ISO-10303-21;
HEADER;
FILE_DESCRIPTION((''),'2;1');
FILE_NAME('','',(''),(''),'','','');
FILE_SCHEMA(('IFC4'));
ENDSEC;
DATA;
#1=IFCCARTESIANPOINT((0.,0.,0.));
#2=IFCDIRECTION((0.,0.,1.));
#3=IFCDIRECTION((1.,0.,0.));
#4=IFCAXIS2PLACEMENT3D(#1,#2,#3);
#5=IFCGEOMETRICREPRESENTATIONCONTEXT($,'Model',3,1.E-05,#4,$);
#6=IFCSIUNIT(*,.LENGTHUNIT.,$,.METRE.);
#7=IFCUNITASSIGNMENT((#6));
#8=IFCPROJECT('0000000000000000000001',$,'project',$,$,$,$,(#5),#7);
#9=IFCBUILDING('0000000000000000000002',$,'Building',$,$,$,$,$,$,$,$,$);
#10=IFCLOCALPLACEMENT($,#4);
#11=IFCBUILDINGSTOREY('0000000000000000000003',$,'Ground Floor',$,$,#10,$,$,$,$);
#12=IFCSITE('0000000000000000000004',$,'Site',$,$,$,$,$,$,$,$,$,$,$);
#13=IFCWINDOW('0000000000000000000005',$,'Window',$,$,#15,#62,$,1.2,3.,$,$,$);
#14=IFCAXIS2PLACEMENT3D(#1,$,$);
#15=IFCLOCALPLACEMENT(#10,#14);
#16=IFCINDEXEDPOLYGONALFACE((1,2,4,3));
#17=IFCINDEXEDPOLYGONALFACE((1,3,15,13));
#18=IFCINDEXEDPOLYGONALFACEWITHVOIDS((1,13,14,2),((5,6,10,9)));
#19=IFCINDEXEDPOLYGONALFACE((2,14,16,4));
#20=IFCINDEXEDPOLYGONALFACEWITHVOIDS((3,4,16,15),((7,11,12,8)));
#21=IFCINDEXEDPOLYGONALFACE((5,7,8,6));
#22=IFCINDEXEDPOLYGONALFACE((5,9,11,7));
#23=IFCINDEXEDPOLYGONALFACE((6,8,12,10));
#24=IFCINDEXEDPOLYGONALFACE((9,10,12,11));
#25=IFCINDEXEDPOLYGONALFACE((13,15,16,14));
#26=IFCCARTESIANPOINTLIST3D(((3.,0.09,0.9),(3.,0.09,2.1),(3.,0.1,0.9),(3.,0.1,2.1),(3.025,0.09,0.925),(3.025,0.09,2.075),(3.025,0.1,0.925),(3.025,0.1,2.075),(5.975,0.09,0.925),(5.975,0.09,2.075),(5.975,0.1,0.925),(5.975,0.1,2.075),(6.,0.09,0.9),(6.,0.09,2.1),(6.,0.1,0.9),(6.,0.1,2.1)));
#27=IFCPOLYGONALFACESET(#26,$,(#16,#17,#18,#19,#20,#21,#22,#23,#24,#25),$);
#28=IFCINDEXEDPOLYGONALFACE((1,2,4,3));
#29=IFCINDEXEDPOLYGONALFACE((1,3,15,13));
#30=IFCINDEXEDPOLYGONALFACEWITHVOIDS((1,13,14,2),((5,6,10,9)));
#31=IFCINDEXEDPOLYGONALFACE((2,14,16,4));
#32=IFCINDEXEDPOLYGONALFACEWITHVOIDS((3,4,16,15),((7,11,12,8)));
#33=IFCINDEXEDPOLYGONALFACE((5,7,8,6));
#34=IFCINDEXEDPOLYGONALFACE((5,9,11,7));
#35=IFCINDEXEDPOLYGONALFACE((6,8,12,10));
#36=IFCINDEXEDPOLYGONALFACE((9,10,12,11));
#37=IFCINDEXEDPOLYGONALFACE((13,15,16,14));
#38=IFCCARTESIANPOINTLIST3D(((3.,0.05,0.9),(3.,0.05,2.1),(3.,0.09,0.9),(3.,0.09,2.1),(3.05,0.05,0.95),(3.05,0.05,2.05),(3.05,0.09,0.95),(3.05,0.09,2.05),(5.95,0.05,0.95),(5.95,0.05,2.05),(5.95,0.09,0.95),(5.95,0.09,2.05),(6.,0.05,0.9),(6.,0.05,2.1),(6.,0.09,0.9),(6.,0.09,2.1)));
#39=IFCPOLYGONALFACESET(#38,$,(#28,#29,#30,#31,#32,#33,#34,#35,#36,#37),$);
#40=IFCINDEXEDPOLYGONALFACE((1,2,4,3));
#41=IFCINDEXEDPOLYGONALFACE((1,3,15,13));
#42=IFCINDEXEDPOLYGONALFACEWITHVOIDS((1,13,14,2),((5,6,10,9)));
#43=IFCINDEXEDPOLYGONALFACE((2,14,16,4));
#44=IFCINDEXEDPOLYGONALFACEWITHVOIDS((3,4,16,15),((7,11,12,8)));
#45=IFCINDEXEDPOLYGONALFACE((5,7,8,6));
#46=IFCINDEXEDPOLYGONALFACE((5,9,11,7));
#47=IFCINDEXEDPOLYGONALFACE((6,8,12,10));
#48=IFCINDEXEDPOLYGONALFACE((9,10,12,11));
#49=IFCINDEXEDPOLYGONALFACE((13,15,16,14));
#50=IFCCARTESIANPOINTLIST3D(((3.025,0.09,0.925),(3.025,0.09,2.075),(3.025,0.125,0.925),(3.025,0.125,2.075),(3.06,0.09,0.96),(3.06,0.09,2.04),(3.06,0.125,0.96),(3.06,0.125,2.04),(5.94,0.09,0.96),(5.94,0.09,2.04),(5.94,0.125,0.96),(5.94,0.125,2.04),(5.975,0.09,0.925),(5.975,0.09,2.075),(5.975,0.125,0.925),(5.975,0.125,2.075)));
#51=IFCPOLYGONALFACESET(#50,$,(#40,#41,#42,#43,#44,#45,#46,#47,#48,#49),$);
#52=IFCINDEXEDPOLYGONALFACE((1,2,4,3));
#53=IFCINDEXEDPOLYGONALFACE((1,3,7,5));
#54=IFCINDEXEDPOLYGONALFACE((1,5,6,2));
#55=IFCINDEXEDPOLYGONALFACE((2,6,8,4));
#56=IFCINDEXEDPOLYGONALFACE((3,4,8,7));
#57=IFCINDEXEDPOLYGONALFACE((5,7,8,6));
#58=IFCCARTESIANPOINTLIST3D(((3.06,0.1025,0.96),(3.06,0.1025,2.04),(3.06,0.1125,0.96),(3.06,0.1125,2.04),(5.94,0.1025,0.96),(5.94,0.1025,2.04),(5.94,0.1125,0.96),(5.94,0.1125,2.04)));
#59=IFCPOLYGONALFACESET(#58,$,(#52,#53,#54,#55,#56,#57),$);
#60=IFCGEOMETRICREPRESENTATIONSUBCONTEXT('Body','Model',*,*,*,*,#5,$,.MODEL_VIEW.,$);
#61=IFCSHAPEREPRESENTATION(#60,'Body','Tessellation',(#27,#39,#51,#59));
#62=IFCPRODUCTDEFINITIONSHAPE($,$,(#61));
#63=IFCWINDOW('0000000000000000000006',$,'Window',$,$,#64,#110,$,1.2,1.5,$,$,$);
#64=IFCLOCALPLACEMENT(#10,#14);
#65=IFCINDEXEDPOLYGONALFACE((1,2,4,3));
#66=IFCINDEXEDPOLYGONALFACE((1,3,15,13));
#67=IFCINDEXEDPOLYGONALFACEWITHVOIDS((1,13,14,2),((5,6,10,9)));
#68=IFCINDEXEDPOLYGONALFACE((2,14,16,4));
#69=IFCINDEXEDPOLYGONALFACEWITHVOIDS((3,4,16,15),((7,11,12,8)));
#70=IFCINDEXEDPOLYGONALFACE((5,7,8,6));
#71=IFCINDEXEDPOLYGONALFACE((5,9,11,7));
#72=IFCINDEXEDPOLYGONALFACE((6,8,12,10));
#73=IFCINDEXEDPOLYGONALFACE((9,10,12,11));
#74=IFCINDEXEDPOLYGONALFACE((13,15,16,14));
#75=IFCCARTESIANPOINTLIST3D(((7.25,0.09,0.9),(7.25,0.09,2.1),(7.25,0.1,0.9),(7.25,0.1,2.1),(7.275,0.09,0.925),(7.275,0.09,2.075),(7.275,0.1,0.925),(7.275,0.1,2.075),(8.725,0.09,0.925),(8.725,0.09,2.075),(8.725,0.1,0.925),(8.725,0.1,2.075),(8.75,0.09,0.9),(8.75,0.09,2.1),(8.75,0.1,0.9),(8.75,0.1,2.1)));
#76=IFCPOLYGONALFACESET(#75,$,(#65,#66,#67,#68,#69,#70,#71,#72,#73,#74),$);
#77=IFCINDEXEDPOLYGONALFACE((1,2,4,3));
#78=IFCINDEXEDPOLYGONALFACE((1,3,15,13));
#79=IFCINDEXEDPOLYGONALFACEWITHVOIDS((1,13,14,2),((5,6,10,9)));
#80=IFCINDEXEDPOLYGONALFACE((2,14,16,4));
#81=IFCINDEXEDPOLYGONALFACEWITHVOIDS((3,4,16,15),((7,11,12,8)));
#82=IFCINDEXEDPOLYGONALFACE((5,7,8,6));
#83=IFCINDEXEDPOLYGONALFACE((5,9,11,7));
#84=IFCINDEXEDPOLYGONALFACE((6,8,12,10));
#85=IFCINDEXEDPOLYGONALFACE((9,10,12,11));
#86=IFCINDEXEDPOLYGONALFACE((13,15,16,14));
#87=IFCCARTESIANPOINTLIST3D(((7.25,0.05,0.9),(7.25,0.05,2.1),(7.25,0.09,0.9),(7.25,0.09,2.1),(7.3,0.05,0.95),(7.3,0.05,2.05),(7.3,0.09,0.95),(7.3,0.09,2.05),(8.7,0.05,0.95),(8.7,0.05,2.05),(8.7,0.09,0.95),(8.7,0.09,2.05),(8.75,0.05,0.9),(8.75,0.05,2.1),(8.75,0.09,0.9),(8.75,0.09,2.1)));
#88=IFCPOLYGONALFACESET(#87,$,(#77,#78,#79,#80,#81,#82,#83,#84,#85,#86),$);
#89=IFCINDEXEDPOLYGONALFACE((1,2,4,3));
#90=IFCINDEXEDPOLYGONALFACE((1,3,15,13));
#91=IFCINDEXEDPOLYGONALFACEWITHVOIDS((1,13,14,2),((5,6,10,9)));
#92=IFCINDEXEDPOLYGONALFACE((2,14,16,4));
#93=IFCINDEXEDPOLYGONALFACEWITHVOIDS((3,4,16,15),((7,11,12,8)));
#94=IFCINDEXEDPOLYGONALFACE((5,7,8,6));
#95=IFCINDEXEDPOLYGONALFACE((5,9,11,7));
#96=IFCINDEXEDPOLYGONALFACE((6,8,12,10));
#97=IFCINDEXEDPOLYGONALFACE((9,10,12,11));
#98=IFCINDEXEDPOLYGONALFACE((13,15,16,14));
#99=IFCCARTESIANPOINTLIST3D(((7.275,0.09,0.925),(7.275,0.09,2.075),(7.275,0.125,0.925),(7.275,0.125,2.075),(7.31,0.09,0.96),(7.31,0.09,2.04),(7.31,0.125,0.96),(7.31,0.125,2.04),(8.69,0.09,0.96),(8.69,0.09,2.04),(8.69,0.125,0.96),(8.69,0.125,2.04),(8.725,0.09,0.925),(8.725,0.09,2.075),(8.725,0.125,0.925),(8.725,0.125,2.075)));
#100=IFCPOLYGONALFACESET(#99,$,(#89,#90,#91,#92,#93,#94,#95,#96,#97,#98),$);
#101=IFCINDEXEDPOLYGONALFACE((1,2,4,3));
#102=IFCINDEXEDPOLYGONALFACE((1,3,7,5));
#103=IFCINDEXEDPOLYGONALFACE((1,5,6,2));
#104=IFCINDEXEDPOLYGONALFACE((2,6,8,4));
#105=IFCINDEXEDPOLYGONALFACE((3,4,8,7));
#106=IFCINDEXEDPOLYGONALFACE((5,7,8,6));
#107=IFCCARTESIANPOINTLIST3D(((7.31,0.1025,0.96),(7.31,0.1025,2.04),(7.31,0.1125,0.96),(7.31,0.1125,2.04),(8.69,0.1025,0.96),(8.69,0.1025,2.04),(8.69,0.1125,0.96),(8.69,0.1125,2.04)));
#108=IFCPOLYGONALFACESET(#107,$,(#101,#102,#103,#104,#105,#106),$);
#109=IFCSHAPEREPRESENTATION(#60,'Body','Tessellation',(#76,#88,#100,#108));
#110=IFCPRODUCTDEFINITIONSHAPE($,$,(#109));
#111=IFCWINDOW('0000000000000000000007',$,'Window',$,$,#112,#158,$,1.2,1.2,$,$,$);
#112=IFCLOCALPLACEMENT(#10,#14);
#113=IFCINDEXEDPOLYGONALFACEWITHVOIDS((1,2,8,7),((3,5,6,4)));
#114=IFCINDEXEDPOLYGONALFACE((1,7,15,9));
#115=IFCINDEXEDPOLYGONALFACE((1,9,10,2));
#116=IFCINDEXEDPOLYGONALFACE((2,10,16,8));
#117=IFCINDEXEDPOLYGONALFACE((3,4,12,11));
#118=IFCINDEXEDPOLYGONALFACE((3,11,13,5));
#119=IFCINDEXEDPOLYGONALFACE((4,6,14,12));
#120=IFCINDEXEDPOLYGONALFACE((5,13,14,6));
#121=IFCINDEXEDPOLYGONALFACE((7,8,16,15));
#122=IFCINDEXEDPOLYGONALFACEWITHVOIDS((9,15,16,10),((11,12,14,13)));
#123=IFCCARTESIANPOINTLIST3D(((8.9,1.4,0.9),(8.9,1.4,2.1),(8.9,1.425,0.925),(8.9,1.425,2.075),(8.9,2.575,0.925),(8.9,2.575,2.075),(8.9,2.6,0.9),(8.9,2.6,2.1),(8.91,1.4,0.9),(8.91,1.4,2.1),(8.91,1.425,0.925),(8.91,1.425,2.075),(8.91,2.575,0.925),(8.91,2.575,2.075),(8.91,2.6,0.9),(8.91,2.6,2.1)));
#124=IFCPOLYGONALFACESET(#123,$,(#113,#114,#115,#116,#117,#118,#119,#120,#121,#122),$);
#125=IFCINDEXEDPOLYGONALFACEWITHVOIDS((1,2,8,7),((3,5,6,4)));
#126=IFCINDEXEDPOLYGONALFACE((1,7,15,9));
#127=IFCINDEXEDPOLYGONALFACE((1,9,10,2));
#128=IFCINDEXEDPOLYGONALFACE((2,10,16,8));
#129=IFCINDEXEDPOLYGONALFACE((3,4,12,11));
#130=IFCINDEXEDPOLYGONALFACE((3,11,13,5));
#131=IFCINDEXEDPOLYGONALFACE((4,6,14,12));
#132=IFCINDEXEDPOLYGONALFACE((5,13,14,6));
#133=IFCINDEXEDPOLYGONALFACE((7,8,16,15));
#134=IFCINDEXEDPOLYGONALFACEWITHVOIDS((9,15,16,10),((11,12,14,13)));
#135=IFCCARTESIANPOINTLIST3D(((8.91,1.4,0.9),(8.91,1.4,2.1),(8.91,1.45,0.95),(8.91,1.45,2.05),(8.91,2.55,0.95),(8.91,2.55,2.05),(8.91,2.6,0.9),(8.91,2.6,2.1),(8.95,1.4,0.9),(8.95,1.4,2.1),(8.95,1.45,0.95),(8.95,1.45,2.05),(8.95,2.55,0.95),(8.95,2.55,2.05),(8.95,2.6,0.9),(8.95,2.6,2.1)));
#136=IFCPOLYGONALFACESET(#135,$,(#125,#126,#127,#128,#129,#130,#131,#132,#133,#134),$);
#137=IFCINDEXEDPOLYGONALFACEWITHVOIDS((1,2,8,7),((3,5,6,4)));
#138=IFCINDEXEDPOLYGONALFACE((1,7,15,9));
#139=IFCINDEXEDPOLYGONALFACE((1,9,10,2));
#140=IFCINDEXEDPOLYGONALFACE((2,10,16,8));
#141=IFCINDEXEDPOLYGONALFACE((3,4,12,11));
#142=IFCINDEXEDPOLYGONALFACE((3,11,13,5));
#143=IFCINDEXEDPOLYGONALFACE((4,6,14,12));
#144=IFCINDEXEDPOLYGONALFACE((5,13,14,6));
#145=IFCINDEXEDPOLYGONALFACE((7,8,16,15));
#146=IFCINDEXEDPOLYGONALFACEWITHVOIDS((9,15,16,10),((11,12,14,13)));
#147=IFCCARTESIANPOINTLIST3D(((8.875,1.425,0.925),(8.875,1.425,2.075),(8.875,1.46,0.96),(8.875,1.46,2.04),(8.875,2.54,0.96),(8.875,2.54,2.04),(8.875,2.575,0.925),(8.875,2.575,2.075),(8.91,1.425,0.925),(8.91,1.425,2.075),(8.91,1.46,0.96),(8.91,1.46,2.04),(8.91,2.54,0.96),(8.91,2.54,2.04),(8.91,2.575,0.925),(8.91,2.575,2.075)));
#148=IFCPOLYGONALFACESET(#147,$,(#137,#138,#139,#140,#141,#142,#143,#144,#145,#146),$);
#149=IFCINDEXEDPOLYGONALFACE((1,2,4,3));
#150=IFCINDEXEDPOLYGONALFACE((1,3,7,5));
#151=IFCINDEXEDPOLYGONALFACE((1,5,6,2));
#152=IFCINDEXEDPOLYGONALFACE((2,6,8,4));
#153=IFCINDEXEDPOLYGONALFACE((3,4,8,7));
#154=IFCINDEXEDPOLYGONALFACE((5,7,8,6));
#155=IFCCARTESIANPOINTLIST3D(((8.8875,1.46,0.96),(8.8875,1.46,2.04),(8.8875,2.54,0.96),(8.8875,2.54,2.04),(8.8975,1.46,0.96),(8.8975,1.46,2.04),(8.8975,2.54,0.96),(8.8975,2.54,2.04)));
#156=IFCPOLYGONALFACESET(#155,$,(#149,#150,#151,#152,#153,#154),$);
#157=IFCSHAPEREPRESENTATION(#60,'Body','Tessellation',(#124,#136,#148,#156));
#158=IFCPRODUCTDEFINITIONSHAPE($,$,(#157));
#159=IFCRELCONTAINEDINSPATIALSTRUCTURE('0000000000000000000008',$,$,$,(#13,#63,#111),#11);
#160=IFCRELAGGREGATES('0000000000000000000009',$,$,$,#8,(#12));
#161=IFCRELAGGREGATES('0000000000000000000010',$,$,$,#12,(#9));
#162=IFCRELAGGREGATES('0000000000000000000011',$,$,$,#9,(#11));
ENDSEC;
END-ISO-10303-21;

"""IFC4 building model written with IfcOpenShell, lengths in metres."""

from ifc_helpers import new_model, si_unit, frame, origin_with_axes, place, context, subcontext, project, spatial, line, indexed_curve, outline, extrude, element, save


model = new_model("IFC4")

# Units and contexts
model_context = context("Model", 3, precision=1e-05, world=origin_with_axes())
body_context = subcontext(model_context, "Body", "Model", "MODEL_VIEW")
ifc_project = project(units=[si_unit("LENGTHUNIT", "METRE")], contexts=[model_context])

# Site, building, storey
site = spatial("IfcSite", under=ifc_project, Name="Site")
building = spatial("IfcBuilding", under=site, Name="Building")
storey_placement = place(None, origin_with_axes())
storey = spatial("IfcBuildingStorey", under=building, at=storey_placement, Name="Ground Floor")

# Windows
window_1_placement = place(storey_placement, frame((3.0, 0.0, 0.9), z_axis=(0.0, 0.0, 1.0), x_axis=(1.0, 0.0, 0.0)))
element("IfcWindow", 1, at=window_1_placement, inside=storey, Name="Window", OverallHeight=1.2, OverallWidth=3.0, context=body_context, shape_type="SweptSolid", body=[
    extrude(outline(indexed_curve([(0.0, 0.0), (3.0, 0.0), (3.0, 1.2), (0.0, 1.2)], segments=[line(1, 2, 3, 4, 1)]), holes=[indexed_curve([(0.025, 0.025), (2.975, 0.025), (2.975, 1.175), (0.025, 1.175)], segments=[line(1, 2, 3, 4, 1)])]), frame((0.0, 0.09, 0.0), z_axis=(0.0, -1.0, 0.0), x_axis=(1.0, 0.0, 0.0)), (0.0, 0.0, -1.0), 0.01),
    extrude(outline(indexed_curve([(0.0, 0.0), (3.0, 0.0), (3.0, 1.2), (0.0, 1.2)], segments=[line(1, 2, 3, 4, 1)]), holes=[indexed_curve([(0.05, 0.05), (2.95, 0.05), (2.95, 1.15), (0.05, 1.15)], segments=[line(1, 2, 3, 4, 1)])]), frame((0.0, 0.05, 0.0), z_axis=(0.0, -1.0, 0.0), x_axis=(1.0, 0.0, 0.0)), (0.0, 0.0, -1.0), 0.04),
    extrude(outline(indexed_curve([(0.0, 0.0), (2.95, 0.0), (2.95, 1.15), (0.0, 1.15)], segments=[line(1, 2, 3, 4, 1)]), holes=[indexed_curve([(0.035, 0.035), (2.915, 0.035), (2.915, 1.115), (0.035, 1.115)], segments=[line(1, 2, 3, 4, 1)])]), frame((0.025, 0.09, 0.025), z_axis=(0.0, -1.0, 0.0), x_axis=(1.0, 0.0, 0.0)), (0.0, 0.0, -1.0), 0.035),
    extrude(outline(indexed_curve([(0.035, 0.035), (2.915, 0.035), (2.915, 1.115), (0.035, 1.115)], segments=[line(1, 2, 3, 4, 1)])), frame((0.025, 0.1025, 0.025), z_axis=(0.0, -1.0, 0.0), x_axis=(1.0, 0.0, 0.0)), (0.0, 0.0, -1.0), 0.01),
])
window_2_placement = place(storey_placement, frame((7.25, 0.0, 0.9), z_axis=(0.0, 0.0, 1.0), x_axis=(1.0, 0.0, 0.0)))
element("IfcWindow", 2, at=window_2_placement, inside=storey, Name="Window", OverallHeight=1.2, OverallWidth=1.5, context=body_context, shape_type="SweptSolid", body=[
    extrude(outline(indexed_curve([(0.0, 0.0), (1.5, 0.0), (1.5, 1.2), (0.0, 1.2)], segments=[line(1, 2, 3, 4, 1)]), holes=[indexed_curve([(0.025, 0.025), (1.475, 0.025), (1.475, 1.175), (0.025, 1.175)], segments=[line(1, 2, 3, 4, 1)])]), frame((0.0, 0.09, 0.0), z_axis=(0.0, -1.0, 0.0), x_axis=(1.0, 0.0, 0.0)), (0.0, 0.0, -1.0), 0.01),
    extrude(outline(indexed_curve([(0.0, 0.0), (1.5, 0.0), (1.5, 1.2), (0.0, 1.2)], segments=[line(1, 2, 3, 4, 1)]), holes=[indexed_curve([(0.05, 0.05), (1.45, 0.05), (1.45, 1.15), (0.05, 1.15)], segments=[line(1, 2, 3, 4, 1)])]), frame((0.0, 0.05, 0.0), z_axis=(0.0, -1.0, 0.0), x_axis=(1.0, 0.0, 0.0)), (0.0, 0.0, -1.0), 0.04),
    extrude(outline(indexed_curve([(0.0, 0.0), (1.45, 0.0), (1.45, 1.15), (0.0, 1.15)], segments=[line(1, 2, 3, 4, 1)]), holes=[indexed_curve([(0.035, 0.035), (1.415, 0.035), (1.415, 1.115), (0.035, 1.115)], segments=[line(1, 2, 3, 4, 1)])]), frame((0.025, 0.09, 0.025), z_axis=(0.0, -1.0, 0.0), x_axis=(1.0, 0.0, 0.0)), (0.0, 0.0, -1.0), 0.035),
    extrude(outline(indexed_curve([(0.035, 0.035), (1.415, 0.035), (1.415, 1.115), (0.035, 1.115)], segments=[line(1, 2, 3, 4, 1)])), frame((0.025, 0.1025, 0.025), z_axis=(0.0, -1.0, 0.0), x_axis=(1.0, 0.0, 0.0)), (0.0, 0.0, -1.0), 0.01),
])
window_3_placement = place(storey_placement, frame((9.0, 1.4, 0.9), z_axis=(0.0, 0.0, 1.0), x_axis=(0.0, 1.0, 0.0)))
element("IfcWindow", 3, at=window_3_placement, inside=storey, Name="Window", OverallHeight=1.2, OverallWidth=1.2, context=body_context, shape_type="SweptSolid", body=[
    extrude(outline(indexed_curve([(0.0, 0.0), (1.2, 0.0), (1.2, 1.2), (0.0, 1.2)], segments=[line(1, 2, 3, 4, 1)]), holes=[indexed_curve([(0.025, 0.025), (1.175, 0.025), (1.175, 1.175), (0.025, 1.175)], segments=[line(1, 2, 3, 4, 1)])]), frame((0.0, 0.09, 0.0), z_axis=(0.0, -1.0, 0.0), x_axis=(1.0, 0.0, 0.0)), (0.0, 0.0, -1.0), 0.01),
    extrude(outline(indexed_curve([(0.0, 0.0), (1.2, 0.0), (1.2, 1.2), (0.0, 1.2)], segments=[line(1, 2, 3, 4, 1)]), holes=[indexed_curve([(0.05, 0.05), (1.15, 0.05), (1.15, 1.15), (0.05, 1.15)], segments=[line(1, 2, 3, 4, 1)])]), frame((0.0, 0.05, 0.0), z_axis=(0.0, -1.0, 0.0), x_axis=(1.0, 0.0, 0.0)), (0.0, 0.0, -1.0), 0.04),
    extrude(outline(indexed_curve([(0.0, 0.0), (1.15, 0.0), (1.15, 1.15), (0.0, 1.15)], segments=[line(1, 2, 3, 4, 1)]), holes=[indexed_curve([(0.035, 0.035), (1.115, 0.035), (1.115, 1.115), (0.035, 1.115)], segments=[line(1, 2, 3, 4, 1)])]), frame((0.025, 0.09, 0.025), z_axis=(0.0, -1.0, 0.0), x_axis=(1.0, 0.0, 0.0)), (0.0, 0.0, -1.0), 0.035),
    extrude(outline(indexed_curve([(0.035, 0.035), (1.115, 0.035), (1.115, 1.115), (0.035, 1.115)], segments=[line(1, 2, 3, 4, 1)])), frame((0.025, 0.1025, 0.025), z_axis=(0.0, -1.0, 0.0), x_axis=(1.0, 0.0, 0.0)), (0.0, 0.0, -1.0), 0.01),
])

save(model, "model.ifc")
